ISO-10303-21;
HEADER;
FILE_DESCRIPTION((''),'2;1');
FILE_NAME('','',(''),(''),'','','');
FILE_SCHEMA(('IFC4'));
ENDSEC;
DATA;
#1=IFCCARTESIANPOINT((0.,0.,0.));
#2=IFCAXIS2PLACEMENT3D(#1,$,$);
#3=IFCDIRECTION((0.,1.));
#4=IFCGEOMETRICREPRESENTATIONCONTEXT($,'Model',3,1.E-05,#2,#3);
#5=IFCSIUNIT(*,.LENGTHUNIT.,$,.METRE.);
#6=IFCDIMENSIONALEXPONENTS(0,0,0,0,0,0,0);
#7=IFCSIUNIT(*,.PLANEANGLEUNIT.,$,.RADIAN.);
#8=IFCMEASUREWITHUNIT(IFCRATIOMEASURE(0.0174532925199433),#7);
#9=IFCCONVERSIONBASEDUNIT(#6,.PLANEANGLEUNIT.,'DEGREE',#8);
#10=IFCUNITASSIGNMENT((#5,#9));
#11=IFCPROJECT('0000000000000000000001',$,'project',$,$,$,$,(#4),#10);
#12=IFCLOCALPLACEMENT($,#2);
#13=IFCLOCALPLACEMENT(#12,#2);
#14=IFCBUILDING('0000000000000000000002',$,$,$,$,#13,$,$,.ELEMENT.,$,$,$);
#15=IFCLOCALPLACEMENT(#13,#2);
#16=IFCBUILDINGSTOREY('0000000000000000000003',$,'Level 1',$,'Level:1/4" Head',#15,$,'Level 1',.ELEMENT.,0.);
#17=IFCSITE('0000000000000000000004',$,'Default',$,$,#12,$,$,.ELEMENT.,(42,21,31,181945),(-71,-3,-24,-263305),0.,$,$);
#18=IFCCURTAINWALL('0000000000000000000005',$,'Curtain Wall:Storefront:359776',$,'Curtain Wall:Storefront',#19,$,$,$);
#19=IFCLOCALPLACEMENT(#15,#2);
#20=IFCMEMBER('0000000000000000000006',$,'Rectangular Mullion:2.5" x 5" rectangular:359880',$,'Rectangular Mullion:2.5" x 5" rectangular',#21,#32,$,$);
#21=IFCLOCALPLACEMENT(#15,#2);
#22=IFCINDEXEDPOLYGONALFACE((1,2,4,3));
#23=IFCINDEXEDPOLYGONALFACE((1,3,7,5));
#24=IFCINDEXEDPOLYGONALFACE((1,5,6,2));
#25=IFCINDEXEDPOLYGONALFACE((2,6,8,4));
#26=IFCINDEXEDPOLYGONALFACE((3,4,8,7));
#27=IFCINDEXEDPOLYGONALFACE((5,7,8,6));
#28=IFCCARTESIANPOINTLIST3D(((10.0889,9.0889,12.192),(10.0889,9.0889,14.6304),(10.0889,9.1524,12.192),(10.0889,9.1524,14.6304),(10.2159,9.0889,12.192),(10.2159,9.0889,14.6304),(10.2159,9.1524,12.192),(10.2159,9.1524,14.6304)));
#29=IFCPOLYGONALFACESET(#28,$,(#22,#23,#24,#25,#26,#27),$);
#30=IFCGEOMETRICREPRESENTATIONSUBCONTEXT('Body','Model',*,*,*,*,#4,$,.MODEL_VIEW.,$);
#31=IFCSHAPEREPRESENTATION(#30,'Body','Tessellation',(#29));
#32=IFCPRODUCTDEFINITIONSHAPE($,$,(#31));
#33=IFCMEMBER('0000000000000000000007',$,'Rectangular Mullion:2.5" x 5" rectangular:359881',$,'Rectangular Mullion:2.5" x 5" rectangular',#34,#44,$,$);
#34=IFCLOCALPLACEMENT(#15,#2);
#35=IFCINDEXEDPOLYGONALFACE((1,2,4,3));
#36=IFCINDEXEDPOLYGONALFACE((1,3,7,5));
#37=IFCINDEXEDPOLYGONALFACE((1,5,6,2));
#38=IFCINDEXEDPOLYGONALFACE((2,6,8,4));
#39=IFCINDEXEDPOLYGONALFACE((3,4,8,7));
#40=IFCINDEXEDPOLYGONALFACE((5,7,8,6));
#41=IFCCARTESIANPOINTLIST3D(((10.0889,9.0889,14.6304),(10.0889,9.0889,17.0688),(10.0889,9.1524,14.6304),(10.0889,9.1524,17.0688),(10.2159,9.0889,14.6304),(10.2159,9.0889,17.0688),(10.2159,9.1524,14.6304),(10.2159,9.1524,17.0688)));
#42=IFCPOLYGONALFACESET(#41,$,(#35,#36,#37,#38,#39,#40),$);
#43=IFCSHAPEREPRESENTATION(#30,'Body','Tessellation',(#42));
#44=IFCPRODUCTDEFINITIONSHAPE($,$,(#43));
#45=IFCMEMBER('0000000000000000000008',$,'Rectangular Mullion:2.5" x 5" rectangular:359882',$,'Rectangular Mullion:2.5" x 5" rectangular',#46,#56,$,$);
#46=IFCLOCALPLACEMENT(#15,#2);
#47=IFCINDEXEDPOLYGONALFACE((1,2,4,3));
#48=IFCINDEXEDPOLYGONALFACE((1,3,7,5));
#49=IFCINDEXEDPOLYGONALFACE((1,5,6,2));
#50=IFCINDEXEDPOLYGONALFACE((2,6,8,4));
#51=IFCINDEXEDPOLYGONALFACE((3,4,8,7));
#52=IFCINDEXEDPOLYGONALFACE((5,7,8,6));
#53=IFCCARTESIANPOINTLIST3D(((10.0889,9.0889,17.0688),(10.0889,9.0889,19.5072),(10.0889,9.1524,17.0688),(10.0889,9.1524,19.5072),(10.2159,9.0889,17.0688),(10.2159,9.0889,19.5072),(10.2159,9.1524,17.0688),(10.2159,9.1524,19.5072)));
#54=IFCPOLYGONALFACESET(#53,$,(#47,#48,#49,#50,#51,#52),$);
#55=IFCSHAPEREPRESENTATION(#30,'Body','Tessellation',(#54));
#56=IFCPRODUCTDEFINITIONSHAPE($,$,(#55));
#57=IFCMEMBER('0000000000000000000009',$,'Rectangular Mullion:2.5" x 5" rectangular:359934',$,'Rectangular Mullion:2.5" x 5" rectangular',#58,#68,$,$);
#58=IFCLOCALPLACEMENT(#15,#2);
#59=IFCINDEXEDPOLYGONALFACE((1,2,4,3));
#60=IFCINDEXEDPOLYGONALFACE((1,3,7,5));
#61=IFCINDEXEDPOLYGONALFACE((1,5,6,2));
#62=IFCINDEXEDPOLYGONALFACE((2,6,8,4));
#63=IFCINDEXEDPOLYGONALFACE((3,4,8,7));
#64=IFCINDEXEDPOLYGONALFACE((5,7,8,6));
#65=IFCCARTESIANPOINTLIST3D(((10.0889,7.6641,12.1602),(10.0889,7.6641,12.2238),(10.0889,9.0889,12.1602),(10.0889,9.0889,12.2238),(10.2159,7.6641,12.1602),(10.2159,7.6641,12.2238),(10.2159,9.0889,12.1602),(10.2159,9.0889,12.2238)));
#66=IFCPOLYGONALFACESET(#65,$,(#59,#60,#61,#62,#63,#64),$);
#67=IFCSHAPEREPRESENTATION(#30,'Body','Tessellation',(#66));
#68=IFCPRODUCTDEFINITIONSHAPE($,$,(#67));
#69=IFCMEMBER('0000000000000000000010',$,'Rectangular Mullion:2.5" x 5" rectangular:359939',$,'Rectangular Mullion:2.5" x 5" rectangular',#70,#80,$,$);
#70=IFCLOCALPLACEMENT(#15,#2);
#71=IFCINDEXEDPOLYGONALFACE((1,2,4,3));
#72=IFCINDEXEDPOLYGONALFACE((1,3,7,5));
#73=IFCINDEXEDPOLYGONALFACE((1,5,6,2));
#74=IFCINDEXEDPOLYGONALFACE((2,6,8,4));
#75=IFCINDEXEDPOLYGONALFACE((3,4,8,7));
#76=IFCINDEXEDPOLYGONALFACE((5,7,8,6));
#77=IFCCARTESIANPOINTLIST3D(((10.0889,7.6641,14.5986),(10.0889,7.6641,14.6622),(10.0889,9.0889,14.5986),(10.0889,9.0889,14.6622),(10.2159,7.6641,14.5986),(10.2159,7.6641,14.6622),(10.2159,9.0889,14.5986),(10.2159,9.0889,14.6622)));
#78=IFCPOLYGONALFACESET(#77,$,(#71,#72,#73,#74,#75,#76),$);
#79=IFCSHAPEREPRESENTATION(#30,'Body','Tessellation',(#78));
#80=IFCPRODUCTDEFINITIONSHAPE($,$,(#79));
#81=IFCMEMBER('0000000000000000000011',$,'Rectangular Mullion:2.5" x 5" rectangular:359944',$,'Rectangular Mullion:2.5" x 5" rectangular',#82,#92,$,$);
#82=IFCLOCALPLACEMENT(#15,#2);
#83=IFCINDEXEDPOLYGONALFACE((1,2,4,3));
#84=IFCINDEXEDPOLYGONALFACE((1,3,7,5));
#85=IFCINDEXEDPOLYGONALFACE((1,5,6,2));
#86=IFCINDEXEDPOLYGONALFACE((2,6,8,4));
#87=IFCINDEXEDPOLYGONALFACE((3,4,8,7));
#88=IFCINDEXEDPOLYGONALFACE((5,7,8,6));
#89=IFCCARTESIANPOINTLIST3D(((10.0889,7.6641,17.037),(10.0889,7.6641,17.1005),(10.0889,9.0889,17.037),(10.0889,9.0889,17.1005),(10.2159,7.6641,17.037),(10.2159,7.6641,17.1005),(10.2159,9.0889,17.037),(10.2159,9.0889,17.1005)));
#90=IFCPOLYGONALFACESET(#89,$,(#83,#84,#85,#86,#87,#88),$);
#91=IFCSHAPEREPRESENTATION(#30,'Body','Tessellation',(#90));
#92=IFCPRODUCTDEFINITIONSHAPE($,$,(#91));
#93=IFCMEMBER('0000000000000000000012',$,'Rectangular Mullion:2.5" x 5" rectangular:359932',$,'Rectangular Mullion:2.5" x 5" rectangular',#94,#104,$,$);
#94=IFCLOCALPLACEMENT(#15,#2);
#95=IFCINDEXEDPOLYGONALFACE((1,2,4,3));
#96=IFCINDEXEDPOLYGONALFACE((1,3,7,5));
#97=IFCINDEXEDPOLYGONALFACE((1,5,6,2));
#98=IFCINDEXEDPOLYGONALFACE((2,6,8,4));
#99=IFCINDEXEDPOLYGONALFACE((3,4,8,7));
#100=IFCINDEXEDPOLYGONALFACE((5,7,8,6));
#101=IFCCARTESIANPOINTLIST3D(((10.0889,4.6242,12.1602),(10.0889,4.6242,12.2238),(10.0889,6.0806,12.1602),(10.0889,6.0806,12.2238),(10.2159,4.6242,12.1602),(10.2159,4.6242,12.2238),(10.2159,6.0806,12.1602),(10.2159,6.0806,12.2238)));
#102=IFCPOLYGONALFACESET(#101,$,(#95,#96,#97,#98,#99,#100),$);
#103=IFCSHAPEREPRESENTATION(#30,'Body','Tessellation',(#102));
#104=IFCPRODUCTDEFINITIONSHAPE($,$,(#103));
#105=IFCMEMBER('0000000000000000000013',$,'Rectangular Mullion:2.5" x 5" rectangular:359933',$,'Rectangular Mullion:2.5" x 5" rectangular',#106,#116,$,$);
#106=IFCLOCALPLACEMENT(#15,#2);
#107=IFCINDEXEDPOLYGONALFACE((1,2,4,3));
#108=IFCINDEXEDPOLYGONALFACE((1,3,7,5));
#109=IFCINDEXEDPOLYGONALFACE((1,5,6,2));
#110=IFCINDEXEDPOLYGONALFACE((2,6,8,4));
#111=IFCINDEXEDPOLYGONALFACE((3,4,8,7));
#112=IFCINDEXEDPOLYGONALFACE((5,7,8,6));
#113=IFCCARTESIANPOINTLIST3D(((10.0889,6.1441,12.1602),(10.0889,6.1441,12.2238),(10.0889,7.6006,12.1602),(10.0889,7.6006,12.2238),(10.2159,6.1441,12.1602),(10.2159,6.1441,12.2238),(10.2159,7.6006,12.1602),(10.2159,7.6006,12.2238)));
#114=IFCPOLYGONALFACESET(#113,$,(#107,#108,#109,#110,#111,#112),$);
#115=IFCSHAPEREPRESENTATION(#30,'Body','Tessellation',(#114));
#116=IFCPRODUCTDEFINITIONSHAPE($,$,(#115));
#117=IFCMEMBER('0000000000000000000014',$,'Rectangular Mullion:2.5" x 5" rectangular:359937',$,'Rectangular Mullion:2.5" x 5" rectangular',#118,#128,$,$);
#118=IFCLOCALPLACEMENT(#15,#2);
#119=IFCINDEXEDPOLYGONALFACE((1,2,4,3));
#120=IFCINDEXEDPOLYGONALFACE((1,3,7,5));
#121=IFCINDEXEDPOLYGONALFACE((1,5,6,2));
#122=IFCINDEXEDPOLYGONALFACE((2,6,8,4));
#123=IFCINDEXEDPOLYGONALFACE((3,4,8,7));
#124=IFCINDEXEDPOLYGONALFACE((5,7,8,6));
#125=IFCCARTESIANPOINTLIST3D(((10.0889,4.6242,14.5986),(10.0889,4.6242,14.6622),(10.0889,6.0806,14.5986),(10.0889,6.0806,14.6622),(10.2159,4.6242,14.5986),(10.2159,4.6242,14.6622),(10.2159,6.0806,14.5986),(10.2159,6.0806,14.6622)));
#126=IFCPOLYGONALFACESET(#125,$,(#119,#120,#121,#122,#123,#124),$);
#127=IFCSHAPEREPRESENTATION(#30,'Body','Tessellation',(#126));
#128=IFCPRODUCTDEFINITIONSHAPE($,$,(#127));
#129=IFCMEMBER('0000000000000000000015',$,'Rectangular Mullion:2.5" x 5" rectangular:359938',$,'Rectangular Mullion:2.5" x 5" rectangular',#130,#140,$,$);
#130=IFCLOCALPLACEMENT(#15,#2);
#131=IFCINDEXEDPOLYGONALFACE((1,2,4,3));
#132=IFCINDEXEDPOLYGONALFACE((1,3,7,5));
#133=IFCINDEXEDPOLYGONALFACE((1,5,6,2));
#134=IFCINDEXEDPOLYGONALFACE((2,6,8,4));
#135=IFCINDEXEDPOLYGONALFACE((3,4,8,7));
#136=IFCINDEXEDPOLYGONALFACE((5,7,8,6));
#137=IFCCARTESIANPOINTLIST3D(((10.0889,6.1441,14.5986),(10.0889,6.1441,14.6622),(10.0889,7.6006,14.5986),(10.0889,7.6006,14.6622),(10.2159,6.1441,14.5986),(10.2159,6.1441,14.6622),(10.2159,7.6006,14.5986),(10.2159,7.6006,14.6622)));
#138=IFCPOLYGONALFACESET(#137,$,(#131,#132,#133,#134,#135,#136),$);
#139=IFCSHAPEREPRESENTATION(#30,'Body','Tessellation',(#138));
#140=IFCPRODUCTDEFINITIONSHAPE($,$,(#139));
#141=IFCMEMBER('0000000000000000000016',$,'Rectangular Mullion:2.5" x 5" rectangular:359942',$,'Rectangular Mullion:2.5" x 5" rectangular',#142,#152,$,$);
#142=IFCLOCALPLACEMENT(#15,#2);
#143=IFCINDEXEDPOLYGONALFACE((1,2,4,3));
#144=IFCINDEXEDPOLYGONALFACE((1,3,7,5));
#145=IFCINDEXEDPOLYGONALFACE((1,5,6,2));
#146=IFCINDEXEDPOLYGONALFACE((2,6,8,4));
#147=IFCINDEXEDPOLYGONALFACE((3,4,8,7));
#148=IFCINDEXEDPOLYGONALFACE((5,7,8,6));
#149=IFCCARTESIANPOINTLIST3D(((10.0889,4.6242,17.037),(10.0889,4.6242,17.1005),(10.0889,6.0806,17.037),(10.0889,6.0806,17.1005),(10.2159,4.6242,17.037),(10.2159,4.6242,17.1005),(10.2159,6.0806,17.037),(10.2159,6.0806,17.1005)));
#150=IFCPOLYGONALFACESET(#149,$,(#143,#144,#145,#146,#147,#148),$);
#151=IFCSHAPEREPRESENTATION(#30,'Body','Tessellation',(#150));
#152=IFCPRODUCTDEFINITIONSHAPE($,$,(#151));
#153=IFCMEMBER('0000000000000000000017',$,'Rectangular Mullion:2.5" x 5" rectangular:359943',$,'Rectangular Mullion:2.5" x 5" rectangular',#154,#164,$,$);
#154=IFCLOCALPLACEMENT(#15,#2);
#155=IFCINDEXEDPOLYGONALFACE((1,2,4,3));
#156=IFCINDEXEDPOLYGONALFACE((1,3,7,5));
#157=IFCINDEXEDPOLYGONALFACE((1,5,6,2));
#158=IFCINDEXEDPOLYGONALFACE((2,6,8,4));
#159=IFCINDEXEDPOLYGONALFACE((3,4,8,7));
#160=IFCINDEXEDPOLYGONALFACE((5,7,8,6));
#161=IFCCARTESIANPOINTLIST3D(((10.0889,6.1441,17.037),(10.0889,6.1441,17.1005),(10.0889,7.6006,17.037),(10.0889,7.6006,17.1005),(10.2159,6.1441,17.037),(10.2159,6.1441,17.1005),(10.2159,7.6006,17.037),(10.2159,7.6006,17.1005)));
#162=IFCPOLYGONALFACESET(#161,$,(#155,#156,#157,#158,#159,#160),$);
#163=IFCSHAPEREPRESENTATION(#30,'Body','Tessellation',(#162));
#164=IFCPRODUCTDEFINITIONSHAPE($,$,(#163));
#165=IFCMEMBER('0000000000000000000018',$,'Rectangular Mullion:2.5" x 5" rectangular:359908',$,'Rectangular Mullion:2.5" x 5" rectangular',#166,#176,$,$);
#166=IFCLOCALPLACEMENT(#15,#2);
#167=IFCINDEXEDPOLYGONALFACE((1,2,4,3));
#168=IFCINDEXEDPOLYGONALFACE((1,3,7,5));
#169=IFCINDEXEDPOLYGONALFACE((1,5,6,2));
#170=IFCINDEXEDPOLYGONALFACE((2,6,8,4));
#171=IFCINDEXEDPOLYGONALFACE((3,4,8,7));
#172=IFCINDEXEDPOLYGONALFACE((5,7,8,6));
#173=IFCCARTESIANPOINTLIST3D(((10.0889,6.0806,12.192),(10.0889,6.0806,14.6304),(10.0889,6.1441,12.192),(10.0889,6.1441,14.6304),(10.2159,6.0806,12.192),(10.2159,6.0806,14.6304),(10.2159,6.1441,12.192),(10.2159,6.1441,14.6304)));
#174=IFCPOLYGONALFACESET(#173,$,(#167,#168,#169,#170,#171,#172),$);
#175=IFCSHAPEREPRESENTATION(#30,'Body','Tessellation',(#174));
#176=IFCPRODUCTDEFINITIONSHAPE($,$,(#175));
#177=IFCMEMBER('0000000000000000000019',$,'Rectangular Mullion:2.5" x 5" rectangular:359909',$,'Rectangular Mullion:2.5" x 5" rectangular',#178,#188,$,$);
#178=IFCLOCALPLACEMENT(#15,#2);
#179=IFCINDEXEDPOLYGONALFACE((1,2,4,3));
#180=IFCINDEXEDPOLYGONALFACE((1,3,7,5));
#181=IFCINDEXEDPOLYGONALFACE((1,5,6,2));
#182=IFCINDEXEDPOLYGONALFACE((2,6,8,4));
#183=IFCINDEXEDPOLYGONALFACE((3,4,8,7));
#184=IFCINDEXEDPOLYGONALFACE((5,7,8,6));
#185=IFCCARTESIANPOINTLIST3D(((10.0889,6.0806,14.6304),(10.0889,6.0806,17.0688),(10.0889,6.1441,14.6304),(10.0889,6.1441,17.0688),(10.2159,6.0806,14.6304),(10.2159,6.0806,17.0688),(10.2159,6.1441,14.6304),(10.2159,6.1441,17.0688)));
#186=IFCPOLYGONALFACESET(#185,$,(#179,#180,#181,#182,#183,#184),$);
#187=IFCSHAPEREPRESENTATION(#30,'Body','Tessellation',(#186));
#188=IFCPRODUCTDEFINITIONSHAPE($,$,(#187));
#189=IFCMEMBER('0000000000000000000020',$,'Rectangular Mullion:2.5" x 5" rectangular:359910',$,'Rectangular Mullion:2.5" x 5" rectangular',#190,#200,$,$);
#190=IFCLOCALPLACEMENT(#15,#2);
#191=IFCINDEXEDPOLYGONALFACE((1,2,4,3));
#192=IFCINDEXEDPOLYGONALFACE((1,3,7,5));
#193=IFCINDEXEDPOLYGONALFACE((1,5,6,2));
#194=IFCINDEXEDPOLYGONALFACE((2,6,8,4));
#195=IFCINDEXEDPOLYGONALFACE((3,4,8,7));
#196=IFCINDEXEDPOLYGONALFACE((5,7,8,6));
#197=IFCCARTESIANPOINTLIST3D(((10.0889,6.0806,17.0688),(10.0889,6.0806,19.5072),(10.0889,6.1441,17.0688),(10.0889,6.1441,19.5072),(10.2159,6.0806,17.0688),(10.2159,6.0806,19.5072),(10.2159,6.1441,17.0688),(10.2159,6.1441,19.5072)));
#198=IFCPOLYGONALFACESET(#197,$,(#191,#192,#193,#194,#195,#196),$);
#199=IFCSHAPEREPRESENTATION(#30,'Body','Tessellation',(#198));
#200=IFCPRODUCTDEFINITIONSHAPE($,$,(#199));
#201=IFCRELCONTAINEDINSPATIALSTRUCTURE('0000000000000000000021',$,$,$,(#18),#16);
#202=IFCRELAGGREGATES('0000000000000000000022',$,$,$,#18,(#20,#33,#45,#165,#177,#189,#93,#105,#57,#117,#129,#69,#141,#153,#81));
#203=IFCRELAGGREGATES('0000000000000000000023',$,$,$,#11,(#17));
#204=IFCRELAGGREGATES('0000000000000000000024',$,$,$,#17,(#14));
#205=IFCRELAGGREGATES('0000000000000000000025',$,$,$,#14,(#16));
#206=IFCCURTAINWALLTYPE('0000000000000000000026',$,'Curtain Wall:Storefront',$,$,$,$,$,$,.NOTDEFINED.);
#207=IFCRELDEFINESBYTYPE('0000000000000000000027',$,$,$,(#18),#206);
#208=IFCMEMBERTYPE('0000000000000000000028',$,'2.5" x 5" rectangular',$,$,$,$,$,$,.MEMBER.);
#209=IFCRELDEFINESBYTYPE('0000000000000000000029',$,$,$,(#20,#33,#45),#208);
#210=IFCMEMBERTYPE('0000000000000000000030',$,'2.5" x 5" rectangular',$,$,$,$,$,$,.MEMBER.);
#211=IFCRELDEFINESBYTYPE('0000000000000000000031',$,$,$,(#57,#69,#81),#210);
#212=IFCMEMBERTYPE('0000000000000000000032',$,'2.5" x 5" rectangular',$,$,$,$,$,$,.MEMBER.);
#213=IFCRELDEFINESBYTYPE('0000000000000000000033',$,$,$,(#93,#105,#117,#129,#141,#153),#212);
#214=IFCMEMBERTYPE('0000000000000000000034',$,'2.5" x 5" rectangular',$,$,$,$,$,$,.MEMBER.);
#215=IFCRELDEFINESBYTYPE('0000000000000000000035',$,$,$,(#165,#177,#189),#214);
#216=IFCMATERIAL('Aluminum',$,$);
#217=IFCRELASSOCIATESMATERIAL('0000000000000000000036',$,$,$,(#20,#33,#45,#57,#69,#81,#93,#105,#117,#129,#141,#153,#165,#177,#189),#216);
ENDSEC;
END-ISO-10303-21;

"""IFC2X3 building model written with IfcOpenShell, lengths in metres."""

from ifc_helpers import new_model, entity, si_unit, converted_unit, direction, frame, origin, origin_2d_with_axis, place, context, subcontext, project, spatial, rectangle, extrude, source, transform, mapped, material, type_object, type_shapes, element, aggregate, save


model = new_model("IFC2X3")

# Units and contexts
model_context = context("Model", 3, precision=1e-05, world=origin(), true_north=direction((0.0, 1.0)))
body_context = subcontext(model_context, "Body", "Model", "MODEL_VIEW")
ifc_project = project(units=[si_unit("LENGTHUNIT", "METRE"), converted_unit("PLANEANGLEUNIT", "DEGREE", entity("IfcRatioMeasure", 0.0174532925199433), si_unit("PLANEANGLEUNIT", "RADIAN"), dimensions=[0, 0, 0, 0, 0, 0, 0])], contexts=[model_context])

# Site, building, storey
site_placement = place(None, origin())
site = spatial("IfcSite", under=ifc_project, at=site_placement, Name="Default", CompositionType="ELEMENT", RefLatitude=(42, 21, 31, 181945), RefLongitude=(-71, -3, -24, -263305), RefElevation=0.0)
building_placement = place(site_placement, origin())
building = spatial("IfcBuilding", under=site, at=building_placement, CompositionType="ELEMENT")
storey_placement = place(building_placement, origin())
storey = spatial("IfcBuildingStorey", under=building, at=storey_placement, Name="Level 1", ObjectType="Level:1/4\" Head", LongName="Level 1", CompositionType="ELEMENT", Elevation=0.0)

# Curtain wall, members
curtain_wall_type = type_object("IfcCurtainWallType", Name="Curtain Wall:Storefront", PredefinedType="NOTDEFINED")
curtain_wall_placement = place(storey_placement, origin())
curtain_wall = element("IfcCurtainWall", 1, at=curtain_wall_placement, inside=storey, type_object=curtain_wall_type, Name="Curtain Wall:Storefront:359776", ObjectType="Curtain Wall:Storefront")
ifc_material_1 = material(Name="Aluminum")
member_type_1 = type_object("IfcMemberType", Name="2.5\" x 5\" rectangular", PredefinedType="MEMBER")
shared_shape_1 = source(origin(), body_context, "Body", "SweptSolid", [
    extrude(rectangle(XDim=0.127, YDim=0.0635, at=origin_2d_with_axis()), frame((-0.0318, 0.0, -2.4384), z_axis=(0.0, 0.0, 1.0), x_axis=(0.0, -1.0, 0.0)), (0.0, 0.0, 1.0), 2.4384),
])
type_shapes(member_type_1, [shared_shape_1])
member_1_placement = place(storey_placement, frame((10.1524, 9.1524, 12.192), z_axis=(0.0, 0.0, -1.0), x_axis=(0.0, 1.0, 0.0)))
member_1 = element("IfcMember", 2, at=member_1_placement, type_object=member_type_1, material=ifc_material_1, Name="Rectangular Mullion:2.5\" x 5\" rectangular:359880", ObjectType="Rectangular Mullion:2.5\" x 5\" rectangular", context=body_context, shape_type="MappedRepresentation", body=[
    mapped(shared_shape_1, transform((0.0, 0.0, 0.0), scale=1.0)),
])
member_2_placement = place(storey_placement, frame((10.1524, 9.1524, 14.6304), z_axis=(0.0, 0.0, -1.0), x_axis=(0.0, 1.0, 0.0)))
member_2 = element("IfcMember", 3, at=member_2_placement, type_object=member_type_1, material=ifc_material_1, Name="Rectangular Mullion:2.5\" x 5\" rectangular:359881", ObjectType="Rectangular Mullion:2.5\" x 5\" rectangular", context=body_context, shape_type="MappedRepresentation", body=[
    mapped(shared_shape_1, transform((0.0, 0.0, 0.0), scale=1.0)),
])
member_3_placement = place(storey_placement, frame((10.1524, 9.1524, 17.0688), z_axis=(0.0, 0.0, -1.0), x_axis=(0.0, 1.0, 0.0)))
member_3 = element("IfcMember", 4, at=member_3_placement, type_object=member_type_1, material=ifc_material_1, Name="Rectangular Mullion:2.5\" x 5\" rectangular:359882", ObjectType="Rectangular Mullion:2.5\" x 5\" rectangular", context=body_context, shape_type="MappedRepresentation", body=[
    mapped(shared_shape_1, transform((0.0, 0.0, 0.0), scale=1.0)),
])
member_type_2 = type_object("IfcMemberType", Name="2.5\" x 5\" rectangular", PredefinedType="MEMBER")
shared_shape_2 = source(origin(), body_context, "Body", "SweptSolid", [
    extrude(rectangle(XDim=0.127, YDim=0.0635, at=origin_2d_with_axis()), frame((0.0, 0.0, -1.4248), z_axis=(0.0, 0.0, 1.0), x_axis=(0.0, -1.0, 0.0)), (0.0, 0.0, 1.0), 1.4248),
])
type_shapes(member_type_2, [shared_shape_2])
member_4_placement = place(storey_placement, frame((10.1524, 9.0889, 12.192), z_axis=(0.0, 1.0, 0.0), x_axis=(0.0, 0.0, 1.0)))
member_4 = element("IfcMember", 5, at=member_4_placement, type_object=member_type_2, material=ifc_material_1, Name="Rectangular Mullion:2.5\" x 5\" rectangular:359934", ObjectType="Rectangular Mullion:2.5\" x 5\" rectangular", context=body_context, shape_type="MappedRepresentation", body=[
    mapped(shared_shape_2, transform((0.0, 0.0, 0.0), scale=1.0)),
])
member_5_placement = place(storey_placement, frame((10.1524, 9.0889, 14.6304), z_axis=(0.0, 1.0, 0.0), x_axis=(0.0, 0.0, 1.0)))
member_5 = element("IfcMember", 6, at=member_5_placement, type_object=member_type_2, material=ifc_material_1, Name="Rectangular Mullion:2.5\" x 5\" rectangular:359939", ObjectType="Rectangular Mullion:2.5\" x 5\" rectangular", context=body_context, shape_type="MappedRepresentation", body=[
    mapped(shared_shape_2, transform((0.0, 0.0, 0.0), scale=1.0)),
])
member_6_placement = place(storey_placement, frame((10.1524, 9.0889, 17.0688), z_axis=(0.0, 1.0, 0.0), x_axis=(0.0, 0.0, 1.0)))
member_6 = element("IfcMember", 7, at=member_6_placement, type_object=member_type_2, material=ifc_material_1, Name="Rectangular Mullion:2.5\" x 5\" rectangular:359944", ObjectType="Rectangular Mullion:2.5\" x 5\" rectangular", context=body_context, shape_type="MappedRepresentation", body=[
    mapped(shared_shape_2, transform((0.0, 0.0, 0.0), scale=1.0)),
])
member_type_3 = type_object("IfcMemberType", Name="2.5\" x 5\" rectangular", PredefinedType="MEMBER")
shared_shape_3 = source(origin(), body_context, "Body", "SweptSolid", [
    extrude(rectangle(XDim=0.127, YDim=0.0635, at=origin_2d_with_axis()), frame((0.0, 0.0, -1.4565), z_axis=(0.0, 0.0, 1.0), x_axis=(0.0, -1.0, 0.0)), (0.0, 0.0, 1.0), 1.4565),
])
type_shapes(member_type_3, [shared_shape_3])
member_7_placement = place(storey_placement, frame((10.1524, 6.0806, 12.192), z_axis=(0.0, 1.0, 0.0), x_axis=(0.0, 0.0, 1.0)))
member_7 = element("IfcMember", 8, at=member_7_placement, type_object=member_type_3, material=ifc_material_1, Name="Rectangular Mullion:2.5\" x 5\" rectangular:359932", ObjectType="Rectangular Mullion:2.5\" x 5\" rectangular", context=body_context, shape_type="MappedRepresentation", body=[
    mapped(shared_shape_3, transform((0.0, 0.0, 0.0), scale=1.0)),
])
member_8_placement = place(storey_placement, frame((10.1524, 7.6006, 12.192), z_axis=(0.0, 1.0, 0.0), x_axis=(0.0, 0.0, 1.0)))
member_8 = element("IfcMember", 9, at=member_8_placement, type_object=member_type_3, material=ifc_material_1, Name="Rectangular Mullion:2.5\" x 5\" rectangular:359933", ObjectType="Rectangular Mullion:2.5\" x 5\" rectangular", context=body_context, shape_type="MappedRepresentation", body=[
    mapped(shared_shape_3, transform((0.0, 0.0, 0.0), scale=1.0)),
])
member_9_placement = place(storey_placement, frame((10.1524, 6.0806, 14.6304), z_axis=(0.0, 1.0, 0.0), x_axis=(0.0, 0.0, 1.0)))
member_9 = element("IfcMember", 10, at=member_9_placement, type_object=member_type_3, material=ifc_material_1, Name="Rectangular Mullion:2.5\" x 5\" rectangular:359937", ObjectType="Rectangular Mullion:2.5\" x 5\" rectangular", context=body_context, shape_type="MappedRepresentation", body=[
    mapped(shared_shape_3, transform((0.0, 0.0, 0.0), scale=1.0)),
])
member_10_placement = place(storey_placement, frame((10.1524, 7.6006, 14.6304), z_axis=(0.0, 1.0, 0.0), x_axis=(0.0, 0.0, 1.0)))
member_10 = element("IfcMember", 11, at=member_10_placement, type_object=member_type_3, material=ifc_material_1, Name="Rectangular Mullion:2.5\" x 5\" rectangular:359938", ObjectType="Rectangular Mullion:2.5\" x 5\" rectangular", context=body_context, shape_type="MappedRepresentation", body=[
    mapped(shared_shape_3, transform((0.0, 0.0, 0.0), scale=1.0)),
])
member_11_placement = place(storey_placement, frame((10.1524, 6.0806, 17.0688), z_axis=(0.0, 1.0, 0.0), x_axis=(0.0, 0.0, 1.0)))
member_11 = element("IfcMember", 12, at=member_11_placement, type_object=member_type_3, material=ifc_material_1, Name="Rectangular Mullion:2.5\" x 5\" rectangular:359942", ObjectType="Rectangular Mullion:2.5\" x 5\" rectangular", context=body_context, shape_type="MappedRepresentation", body=[
    mapped(shared_shape_3, transform((0.0, 0.0, 0.0), scale=1.0)),
])
member_12_placement = place(storey_placement, frame((10.1524, 7.6006, 17.0688), z_axis=(0.0, 1.0, 0.0), x_axis=(0.0, 0.0, 1.0)))
member_12 = element("IfcMember", 13, at=member_12_placement, type_object=member_type_3, material=ifc_material_1, Name="Rectangular Mullion:2.5\" x 5\" rectangular:359943", ObjectType="Rectangular Mullion:2.5\" x 5\" rectangular", context=body_context, shape_type="MappedRepresentation", body=[
    mapped(shared_shape_3, transform((0.0, 0.0, 0.0), scale=1.0)),
])
member_type_4 = type_object("IfcMemberType", Name="2.5\" x 5\" rectangular", PredefinedType="MEMBER")
shared_shape_4 = source(origin(), body_context, "Body", "SweptSolid", [
    extrude(rectangle(XDim=0.127, YDim=0.0635, at=origin_2d_with_axis()), frame((0.0, 0.0, -2.4384), z_axis=(0.0, 0.0, 1.0), x_axis=(0.0, -1.0, 0.0)), (0.0, 0.0, 1.0), 2.4384),
])
type_shapes(member_type_4, [shared_shape_4])
member_13_placement = place(storey_placement, frame((10.1524, 6.1124, 12.192), z_axis=(0.0, 0.0, -1.0), x_axis=(0.0, 1.0, 0.0)))
member_13 = element("IfcMember", 14, at=member_13_placement, type_object=member_type_4, material=ifc_material_1, Name="Rectangular Mullion:2.5\" x 5\" rectangular:359908", ObjectType="Rectangular Mullion:2.5\" x 5\" rectangular", context=body_context, shape_type="MappedRepresentation", body=[
    mapped(shared_shape_4, transform((0.0, 0.0, 0.0), scale=1.0)),
])
member_14_placement = place(storey_placement, frame((10.1524, 6.1124, 14.6304), z_axis=(0.0, 0.0, -1.0), x_axis=(0.0, 1.0, 0.0)))
member_14 = element("IfcMember", 15, at=member_14_placement, type_object=member_type_4, material=ifc_material_1, Name="Rectangular Mullion:2.5\" x 5\" rectangular:359909", ObjectType="Rectangular Mullion:2.5\" x 5\" rectangular", context=body_context, shape_type="MappedRepresentation", body=[
    mapped(shared_shape_4, transform((0.0, 0.0, 0.0), scale=1.0)),
])
member_15_placement = place(storey_placement, frame((10.1524, 6.1124, 17.0688), z_axis=(0.0, 0.0, -1.0), x_axis=(0.0, 1.0, 0.0)))
member_15 = element("IfcMember", 16, at=member_15_placement, type_object=member_type_4, material=ifc_material_1, Name="Rectangular Mullion:2.5\" x 5\" rectangular:359910", ObjectType="Rectangular Mullion:2.5\" x 5\" rectangular", context=body_context, shape_type="MappedRepresentation", body=[
    mapped(shared_shape_4, transform((0.0, 0.0, 0.0), scale=1.0)),
])
aggregate(curtain_wall, [member_1, member_2, member_3, member_13, member_14, member_15, member_7, member_8, member_4, member_9, member_10, member_5, member_11, member_12, member_6])

save(model, "model.ifc")
